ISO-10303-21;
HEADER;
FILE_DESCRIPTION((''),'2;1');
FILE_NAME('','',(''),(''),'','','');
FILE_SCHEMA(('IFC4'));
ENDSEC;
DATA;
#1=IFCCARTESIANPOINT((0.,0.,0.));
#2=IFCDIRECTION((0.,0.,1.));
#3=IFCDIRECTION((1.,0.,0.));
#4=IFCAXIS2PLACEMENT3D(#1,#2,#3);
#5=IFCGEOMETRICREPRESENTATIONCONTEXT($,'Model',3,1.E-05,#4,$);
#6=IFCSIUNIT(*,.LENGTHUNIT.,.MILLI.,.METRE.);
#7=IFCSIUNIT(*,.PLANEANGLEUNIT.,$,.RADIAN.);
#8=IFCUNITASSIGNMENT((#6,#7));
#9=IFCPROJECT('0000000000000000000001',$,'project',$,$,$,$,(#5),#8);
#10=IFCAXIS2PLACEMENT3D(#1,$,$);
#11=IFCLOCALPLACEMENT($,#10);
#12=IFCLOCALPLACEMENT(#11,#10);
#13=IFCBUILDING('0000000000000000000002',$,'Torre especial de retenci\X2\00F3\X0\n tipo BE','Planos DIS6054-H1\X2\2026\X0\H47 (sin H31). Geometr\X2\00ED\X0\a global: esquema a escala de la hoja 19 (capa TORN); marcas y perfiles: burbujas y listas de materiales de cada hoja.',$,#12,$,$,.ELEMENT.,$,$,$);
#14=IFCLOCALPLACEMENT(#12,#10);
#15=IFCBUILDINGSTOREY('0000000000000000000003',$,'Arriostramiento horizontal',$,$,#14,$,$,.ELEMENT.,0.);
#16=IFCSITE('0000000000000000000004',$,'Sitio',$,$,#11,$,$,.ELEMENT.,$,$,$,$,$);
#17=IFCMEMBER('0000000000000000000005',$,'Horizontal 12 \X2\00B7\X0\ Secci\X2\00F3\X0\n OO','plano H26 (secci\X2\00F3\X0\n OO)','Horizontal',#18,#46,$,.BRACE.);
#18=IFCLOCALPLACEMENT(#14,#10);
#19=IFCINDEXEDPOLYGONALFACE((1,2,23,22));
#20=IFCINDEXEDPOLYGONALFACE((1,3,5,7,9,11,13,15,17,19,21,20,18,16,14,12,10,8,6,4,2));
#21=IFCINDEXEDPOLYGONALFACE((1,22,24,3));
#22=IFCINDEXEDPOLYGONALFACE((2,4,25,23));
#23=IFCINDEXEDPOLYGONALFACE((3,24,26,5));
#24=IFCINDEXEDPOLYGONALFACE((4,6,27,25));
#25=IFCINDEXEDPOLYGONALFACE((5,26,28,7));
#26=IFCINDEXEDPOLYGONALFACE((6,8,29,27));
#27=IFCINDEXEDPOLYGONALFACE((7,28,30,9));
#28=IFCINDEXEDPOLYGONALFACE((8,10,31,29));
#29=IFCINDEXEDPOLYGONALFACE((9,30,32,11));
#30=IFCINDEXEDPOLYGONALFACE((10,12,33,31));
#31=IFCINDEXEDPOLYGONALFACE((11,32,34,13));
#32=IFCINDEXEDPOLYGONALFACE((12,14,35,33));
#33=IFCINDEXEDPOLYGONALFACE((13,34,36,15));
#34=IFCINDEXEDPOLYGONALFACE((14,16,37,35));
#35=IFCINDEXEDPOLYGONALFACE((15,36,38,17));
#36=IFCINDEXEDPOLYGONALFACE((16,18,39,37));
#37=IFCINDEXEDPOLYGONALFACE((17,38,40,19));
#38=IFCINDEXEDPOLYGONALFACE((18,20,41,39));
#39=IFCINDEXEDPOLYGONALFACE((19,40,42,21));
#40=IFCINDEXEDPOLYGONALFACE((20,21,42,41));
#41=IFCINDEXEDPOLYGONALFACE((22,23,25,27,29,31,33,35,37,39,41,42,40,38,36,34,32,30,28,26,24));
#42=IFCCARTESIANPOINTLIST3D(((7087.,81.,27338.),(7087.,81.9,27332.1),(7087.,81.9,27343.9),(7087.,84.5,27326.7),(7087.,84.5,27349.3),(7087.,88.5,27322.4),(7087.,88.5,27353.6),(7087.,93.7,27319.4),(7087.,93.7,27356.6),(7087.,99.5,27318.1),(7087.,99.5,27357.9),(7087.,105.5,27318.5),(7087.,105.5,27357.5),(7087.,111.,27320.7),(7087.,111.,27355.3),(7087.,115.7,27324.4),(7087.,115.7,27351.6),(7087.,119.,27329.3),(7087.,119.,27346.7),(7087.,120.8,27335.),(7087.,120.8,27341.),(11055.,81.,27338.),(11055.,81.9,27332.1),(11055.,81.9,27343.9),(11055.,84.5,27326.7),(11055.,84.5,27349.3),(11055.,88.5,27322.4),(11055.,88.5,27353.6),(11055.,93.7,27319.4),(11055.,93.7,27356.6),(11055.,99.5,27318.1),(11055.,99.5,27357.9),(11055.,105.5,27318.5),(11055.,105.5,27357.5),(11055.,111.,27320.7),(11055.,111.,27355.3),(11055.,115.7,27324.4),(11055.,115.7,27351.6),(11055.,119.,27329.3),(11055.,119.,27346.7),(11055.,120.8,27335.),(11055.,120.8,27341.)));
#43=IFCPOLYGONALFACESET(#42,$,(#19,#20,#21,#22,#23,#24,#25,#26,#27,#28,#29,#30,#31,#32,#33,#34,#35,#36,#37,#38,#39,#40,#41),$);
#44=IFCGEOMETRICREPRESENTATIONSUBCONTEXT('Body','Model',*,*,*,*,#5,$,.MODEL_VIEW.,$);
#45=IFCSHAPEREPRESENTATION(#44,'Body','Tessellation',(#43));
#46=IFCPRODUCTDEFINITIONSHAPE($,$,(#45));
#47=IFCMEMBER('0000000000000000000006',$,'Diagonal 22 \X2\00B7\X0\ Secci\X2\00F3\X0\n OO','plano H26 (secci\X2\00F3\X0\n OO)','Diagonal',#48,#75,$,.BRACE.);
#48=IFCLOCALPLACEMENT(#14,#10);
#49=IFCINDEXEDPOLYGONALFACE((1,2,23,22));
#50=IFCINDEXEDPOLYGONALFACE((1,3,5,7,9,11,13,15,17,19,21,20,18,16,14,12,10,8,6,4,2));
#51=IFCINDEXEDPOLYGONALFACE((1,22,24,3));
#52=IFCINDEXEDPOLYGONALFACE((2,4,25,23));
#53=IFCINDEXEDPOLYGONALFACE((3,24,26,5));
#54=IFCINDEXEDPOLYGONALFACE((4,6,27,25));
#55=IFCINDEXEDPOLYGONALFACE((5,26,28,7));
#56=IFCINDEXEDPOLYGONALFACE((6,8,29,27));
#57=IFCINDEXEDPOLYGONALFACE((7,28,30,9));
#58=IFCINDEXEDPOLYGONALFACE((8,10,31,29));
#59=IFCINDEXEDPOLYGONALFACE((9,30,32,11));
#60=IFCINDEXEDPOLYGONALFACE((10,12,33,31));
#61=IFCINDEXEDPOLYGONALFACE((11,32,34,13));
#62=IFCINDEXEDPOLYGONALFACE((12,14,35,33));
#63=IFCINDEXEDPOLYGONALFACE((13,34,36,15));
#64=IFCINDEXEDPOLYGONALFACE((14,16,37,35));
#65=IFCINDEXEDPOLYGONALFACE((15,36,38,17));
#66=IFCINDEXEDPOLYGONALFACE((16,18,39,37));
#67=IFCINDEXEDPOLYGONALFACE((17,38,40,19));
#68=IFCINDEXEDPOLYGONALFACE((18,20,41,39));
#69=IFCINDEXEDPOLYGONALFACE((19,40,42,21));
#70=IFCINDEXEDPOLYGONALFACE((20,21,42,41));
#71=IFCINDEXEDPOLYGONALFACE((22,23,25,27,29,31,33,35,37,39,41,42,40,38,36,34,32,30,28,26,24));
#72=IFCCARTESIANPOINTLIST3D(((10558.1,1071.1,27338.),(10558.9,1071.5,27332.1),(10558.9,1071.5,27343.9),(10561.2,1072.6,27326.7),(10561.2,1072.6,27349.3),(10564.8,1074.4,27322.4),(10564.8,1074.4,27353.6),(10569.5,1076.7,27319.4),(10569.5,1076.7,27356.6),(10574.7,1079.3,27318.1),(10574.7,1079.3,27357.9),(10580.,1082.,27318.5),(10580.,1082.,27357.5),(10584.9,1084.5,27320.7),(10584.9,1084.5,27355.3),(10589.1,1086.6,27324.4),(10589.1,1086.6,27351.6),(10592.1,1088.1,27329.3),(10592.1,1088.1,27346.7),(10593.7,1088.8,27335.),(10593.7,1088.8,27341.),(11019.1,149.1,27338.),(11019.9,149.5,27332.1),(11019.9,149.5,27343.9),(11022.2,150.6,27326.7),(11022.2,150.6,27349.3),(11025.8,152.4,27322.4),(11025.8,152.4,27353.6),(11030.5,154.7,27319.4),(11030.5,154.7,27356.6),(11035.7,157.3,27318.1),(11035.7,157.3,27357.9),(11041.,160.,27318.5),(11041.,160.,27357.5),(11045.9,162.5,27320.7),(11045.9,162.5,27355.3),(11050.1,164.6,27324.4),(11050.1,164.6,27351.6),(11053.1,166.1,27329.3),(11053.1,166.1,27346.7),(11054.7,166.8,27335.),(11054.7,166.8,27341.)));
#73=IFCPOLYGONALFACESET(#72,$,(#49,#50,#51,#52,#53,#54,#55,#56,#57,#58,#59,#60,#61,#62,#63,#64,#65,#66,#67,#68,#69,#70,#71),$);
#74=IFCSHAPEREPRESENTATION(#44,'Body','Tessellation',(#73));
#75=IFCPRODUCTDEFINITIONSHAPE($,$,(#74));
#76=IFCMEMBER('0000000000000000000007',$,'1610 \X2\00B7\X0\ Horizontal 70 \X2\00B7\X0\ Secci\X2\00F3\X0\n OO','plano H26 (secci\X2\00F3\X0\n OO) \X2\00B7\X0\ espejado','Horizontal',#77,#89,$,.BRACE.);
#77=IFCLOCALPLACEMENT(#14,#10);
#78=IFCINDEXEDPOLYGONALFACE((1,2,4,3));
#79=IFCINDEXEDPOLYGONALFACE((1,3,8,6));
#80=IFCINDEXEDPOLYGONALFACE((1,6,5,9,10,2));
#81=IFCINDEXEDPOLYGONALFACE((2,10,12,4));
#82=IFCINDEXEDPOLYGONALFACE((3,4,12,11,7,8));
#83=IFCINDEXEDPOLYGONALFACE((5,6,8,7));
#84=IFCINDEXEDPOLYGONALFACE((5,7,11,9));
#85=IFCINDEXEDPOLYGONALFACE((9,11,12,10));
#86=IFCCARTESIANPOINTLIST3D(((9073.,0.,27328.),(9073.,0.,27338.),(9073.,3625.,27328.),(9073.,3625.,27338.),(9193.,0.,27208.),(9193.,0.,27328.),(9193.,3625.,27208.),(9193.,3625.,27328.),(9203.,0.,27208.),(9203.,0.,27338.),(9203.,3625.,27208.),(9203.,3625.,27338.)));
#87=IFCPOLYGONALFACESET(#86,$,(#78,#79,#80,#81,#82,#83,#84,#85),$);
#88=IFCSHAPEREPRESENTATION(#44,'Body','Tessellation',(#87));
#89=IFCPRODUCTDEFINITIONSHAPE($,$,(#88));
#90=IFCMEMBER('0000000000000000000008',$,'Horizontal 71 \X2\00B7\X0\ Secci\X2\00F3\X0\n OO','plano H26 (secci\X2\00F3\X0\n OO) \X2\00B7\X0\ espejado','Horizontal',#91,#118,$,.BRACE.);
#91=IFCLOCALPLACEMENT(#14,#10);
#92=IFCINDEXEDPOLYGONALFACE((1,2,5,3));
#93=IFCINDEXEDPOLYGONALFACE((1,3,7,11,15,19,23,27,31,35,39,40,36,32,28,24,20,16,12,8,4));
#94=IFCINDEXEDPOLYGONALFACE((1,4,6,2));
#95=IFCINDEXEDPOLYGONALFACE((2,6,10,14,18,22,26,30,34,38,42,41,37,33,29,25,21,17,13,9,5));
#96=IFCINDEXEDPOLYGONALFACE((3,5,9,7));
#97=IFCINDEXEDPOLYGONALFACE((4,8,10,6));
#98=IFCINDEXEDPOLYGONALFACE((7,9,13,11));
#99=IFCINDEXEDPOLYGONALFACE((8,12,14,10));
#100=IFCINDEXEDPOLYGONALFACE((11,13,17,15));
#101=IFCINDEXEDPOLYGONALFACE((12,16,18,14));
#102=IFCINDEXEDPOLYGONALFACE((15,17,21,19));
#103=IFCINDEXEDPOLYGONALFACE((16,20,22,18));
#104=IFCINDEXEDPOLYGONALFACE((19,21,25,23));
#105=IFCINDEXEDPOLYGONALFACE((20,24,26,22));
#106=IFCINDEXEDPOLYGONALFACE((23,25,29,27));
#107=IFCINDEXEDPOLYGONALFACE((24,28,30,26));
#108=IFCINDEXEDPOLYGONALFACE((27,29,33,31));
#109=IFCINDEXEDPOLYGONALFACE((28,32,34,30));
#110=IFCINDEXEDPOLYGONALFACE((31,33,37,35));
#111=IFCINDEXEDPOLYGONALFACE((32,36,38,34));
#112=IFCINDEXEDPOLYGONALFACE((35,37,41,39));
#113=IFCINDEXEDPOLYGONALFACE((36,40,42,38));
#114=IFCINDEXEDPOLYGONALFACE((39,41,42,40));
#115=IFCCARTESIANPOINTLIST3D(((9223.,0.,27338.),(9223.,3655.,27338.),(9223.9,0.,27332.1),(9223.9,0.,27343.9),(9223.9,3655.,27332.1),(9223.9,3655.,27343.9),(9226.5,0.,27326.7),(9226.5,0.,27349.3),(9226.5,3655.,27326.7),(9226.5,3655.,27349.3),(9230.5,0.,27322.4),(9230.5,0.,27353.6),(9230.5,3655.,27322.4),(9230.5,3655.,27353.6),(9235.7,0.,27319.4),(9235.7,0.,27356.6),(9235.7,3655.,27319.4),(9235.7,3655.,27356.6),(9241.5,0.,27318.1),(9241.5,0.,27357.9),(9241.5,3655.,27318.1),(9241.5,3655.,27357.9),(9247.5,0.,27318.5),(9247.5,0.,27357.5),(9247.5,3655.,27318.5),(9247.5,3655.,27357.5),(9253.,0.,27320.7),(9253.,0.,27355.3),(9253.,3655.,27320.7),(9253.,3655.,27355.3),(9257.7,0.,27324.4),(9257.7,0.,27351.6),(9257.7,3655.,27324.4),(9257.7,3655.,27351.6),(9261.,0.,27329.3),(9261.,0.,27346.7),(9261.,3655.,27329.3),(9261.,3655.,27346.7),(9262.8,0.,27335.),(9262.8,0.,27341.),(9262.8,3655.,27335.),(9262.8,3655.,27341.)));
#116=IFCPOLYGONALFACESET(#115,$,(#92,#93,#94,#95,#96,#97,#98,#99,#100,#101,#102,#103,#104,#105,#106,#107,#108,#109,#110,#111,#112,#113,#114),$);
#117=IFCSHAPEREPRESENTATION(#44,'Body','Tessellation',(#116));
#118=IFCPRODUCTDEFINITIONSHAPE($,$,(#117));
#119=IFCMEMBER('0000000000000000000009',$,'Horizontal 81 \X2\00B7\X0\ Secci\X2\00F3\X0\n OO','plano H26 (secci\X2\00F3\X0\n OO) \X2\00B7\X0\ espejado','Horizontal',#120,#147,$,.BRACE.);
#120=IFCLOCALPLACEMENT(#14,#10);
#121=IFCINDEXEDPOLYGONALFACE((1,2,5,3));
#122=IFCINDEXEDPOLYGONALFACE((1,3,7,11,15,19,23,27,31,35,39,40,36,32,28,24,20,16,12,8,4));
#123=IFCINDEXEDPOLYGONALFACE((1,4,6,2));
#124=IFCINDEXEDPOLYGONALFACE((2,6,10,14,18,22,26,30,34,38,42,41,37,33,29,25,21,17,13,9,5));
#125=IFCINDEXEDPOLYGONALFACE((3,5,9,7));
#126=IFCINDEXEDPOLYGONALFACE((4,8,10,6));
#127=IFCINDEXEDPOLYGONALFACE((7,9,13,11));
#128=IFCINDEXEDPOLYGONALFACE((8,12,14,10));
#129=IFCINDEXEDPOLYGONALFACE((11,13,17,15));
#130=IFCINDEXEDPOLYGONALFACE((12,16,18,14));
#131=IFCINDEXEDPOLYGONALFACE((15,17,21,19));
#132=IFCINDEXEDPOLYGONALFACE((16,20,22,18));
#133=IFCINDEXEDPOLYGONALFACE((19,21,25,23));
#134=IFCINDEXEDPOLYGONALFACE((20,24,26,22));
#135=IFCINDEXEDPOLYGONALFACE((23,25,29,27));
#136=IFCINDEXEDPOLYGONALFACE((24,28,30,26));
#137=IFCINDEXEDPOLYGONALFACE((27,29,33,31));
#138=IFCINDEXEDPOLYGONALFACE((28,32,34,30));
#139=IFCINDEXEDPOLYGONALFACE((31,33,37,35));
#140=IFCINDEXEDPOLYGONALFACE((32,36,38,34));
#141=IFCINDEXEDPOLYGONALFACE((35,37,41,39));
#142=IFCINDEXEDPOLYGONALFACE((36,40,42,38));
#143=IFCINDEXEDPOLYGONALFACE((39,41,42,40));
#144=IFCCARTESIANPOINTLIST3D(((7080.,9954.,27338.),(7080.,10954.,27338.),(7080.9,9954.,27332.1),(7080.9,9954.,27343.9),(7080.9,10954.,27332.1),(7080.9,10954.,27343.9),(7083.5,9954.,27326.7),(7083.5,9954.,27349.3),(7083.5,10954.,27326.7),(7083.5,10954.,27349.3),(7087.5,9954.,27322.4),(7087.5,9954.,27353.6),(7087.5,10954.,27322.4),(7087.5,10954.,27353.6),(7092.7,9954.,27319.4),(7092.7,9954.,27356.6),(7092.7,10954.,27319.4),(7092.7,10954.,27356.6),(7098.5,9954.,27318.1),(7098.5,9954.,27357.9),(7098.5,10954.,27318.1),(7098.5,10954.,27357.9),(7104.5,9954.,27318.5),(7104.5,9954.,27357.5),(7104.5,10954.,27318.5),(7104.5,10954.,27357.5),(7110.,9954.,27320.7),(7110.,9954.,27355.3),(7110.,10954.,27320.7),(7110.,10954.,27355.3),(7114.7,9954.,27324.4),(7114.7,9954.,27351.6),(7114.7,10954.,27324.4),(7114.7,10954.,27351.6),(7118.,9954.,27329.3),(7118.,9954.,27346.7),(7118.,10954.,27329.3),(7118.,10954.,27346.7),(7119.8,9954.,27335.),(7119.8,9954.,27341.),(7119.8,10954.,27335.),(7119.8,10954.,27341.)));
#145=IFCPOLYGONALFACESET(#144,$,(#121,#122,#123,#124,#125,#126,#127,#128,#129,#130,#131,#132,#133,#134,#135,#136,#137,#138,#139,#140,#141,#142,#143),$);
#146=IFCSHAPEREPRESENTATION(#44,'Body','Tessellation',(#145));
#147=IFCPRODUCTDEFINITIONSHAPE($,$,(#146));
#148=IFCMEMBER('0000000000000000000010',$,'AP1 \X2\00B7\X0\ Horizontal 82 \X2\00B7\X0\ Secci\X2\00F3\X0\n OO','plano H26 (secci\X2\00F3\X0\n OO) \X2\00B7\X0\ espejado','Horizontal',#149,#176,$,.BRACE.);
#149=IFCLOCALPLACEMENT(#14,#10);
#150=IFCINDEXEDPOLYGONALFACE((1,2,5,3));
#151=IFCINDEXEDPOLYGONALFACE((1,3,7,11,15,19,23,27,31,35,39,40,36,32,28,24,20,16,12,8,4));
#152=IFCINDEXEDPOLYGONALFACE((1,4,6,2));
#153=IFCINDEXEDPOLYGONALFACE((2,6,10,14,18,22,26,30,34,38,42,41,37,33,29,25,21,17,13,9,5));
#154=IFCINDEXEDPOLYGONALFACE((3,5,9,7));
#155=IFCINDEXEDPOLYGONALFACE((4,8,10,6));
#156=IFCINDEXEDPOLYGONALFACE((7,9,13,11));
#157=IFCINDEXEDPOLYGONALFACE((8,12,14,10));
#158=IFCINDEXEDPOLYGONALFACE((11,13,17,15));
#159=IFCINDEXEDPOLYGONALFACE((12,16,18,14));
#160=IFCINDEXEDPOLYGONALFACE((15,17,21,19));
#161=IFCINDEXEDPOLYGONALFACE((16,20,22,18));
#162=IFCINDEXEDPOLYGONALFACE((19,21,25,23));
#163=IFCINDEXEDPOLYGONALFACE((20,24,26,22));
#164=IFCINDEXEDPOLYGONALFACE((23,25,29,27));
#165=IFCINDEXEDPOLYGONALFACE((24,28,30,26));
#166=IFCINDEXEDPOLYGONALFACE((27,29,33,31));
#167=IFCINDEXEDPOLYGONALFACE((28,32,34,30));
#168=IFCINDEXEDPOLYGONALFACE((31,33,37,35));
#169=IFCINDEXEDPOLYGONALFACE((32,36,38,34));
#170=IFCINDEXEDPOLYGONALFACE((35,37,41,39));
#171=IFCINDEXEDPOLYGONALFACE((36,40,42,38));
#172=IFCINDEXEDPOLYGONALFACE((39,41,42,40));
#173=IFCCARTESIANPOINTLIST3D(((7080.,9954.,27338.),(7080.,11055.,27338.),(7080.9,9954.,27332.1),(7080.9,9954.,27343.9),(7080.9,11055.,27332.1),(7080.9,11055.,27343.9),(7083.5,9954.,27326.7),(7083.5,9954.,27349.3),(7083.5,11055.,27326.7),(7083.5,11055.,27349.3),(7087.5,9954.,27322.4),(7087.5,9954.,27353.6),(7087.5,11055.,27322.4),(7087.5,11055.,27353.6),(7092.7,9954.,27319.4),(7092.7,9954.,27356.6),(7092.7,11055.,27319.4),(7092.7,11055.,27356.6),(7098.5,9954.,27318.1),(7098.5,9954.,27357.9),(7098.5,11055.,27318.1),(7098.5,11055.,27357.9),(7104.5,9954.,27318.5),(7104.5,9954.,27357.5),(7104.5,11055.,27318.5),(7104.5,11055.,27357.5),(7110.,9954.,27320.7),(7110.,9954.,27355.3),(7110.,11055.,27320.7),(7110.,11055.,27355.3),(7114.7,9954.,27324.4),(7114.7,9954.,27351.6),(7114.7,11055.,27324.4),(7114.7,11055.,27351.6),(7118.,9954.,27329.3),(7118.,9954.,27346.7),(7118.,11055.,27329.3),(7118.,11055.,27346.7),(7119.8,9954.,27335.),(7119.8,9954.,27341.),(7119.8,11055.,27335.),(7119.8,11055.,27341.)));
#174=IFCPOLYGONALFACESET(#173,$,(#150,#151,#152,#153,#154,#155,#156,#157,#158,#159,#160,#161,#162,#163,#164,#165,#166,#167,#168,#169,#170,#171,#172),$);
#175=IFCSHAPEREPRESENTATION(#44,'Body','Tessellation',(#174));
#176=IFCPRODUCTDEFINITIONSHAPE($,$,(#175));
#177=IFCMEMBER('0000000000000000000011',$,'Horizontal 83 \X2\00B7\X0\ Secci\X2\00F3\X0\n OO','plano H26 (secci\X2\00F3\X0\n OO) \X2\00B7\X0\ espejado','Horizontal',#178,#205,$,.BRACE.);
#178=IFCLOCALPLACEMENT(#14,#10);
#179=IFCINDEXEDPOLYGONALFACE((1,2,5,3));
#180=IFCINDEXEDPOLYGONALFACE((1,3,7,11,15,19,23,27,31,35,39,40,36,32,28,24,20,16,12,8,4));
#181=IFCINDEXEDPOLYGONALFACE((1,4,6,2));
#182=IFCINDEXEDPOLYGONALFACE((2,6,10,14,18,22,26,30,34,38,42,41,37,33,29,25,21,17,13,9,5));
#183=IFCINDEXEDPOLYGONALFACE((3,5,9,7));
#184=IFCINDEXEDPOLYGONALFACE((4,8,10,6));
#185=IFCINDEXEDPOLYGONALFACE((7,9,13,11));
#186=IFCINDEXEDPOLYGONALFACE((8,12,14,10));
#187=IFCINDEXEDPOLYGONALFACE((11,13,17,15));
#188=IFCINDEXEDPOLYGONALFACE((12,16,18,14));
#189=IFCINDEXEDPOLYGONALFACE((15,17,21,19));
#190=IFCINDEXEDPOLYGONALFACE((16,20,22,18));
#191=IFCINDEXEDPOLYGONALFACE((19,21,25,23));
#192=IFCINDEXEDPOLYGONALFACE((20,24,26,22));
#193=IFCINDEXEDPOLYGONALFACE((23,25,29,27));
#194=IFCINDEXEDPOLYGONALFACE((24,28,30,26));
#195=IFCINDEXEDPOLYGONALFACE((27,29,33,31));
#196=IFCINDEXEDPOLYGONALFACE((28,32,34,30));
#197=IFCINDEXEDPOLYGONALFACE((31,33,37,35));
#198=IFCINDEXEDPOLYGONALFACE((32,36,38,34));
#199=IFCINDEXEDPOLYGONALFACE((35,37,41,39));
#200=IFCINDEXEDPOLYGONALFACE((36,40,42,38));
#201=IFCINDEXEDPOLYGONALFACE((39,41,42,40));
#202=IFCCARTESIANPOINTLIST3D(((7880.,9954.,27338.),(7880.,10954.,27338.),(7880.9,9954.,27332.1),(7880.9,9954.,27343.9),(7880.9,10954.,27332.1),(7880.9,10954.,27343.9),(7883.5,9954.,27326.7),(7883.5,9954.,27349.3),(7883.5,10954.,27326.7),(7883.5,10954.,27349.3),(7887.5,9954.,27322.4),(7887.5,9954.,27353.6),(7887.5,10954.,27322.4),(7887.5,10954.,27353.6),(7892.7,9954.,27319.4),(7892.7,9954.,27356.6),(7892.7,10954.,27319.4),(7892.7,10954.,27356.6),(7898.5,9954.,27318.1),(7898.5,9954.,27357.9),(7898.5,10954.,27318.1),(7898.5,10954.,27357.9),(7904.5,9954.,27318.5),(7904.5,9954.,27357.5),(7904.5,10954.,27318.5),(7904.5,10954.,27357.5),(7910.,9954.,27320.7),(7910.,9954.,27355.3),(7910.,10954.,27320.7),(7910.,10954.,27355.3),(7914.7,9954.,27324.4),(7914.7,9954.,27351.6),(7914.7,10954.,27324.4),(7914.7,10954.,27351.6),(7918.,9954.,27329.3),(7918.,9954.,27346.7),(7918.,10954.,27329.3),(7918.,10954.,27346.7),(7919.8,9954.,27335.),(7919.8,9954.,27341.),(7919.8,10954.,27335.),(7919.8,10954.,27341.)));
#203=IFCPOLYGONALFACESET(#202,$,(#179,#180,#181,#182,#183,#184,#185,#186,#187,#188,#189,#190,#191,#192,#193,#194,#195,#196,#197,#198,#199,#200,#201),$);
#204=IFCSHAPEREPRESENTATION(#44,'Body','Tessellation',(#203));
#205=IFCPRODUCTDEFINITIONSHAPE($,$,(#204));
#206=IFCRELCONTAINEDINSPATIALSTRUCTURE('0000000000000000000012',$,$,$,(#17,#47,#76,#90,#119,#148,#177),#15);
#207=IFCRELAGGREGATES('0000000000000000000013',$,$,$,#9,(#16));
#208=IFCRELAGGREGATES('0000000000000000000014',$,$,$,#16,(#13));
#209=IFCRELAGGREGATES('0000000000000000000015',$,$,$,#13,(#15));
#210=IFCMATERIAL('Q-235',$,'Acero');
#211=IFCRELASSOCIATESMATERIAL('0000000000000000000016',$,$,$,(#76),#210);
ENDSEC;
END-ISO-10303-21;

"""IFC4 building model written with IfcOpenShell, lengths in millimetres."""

from ifc_helpers import new_model, si_unit, frame, frame_2d, origin, origin_with_axes, place, context, subcontext, project, spatial, circle, l_section, extrude, material, element, save


model = new_model("IFC4")

# Units and contexts
model_context = context("Model", 3, precision=1e-05, world=origin_with_axes())
body_context = subcontext(model_context, "Body", "Model", "MODEL_VIEW")
ifc_project = project(units=[si_unit("LENGTHUNIT", "METRE", prefix="MILLI"), si_unit("PLANEANGLEUNIT", "RADIAN")], contexts=[model_context])

# Site, building, storey
site_placement = place(None, origin())
site = spatial("IfcSite", under=ifc_project, at=site_placement, Name="Sitio", CompositionType="ELEMENT")
building_placement = place(site_placement, origin())
building = spatial("IfcBuilding", under=site, at=building_placement, Name="Torre especial de retención tipo BE", Description="Planos DIS6054-H1…H47 (sin H31). Geometría global: esquema a escala de la hoja 19 (capa TORN); marcas y perfiles: burbujas y listas de materiales de cada hoja.", CompositionType="ELEMENT")
storey_placement = place(building_placement, origin())
storey = spatial("IfcBuildingStorey", under=building, at=storey_placement, Name="Arriostramiento horizontal", CompositionType="ELEMENT", Elevation=0.0)

# Members
member_1_placement = place(storey_placement, frame((7087.0, 101.0, 27338.0), z_axis=(1.0, 0.0, 0.0), x_axis=(0.0, -1.0, 0.0)))
element("IfcMember", 1, at=member_1_placement, inside=storey, Name="Horizontal 12 · Sección OO", Description="plano H26 (sección OO)", ObjectType="Horizontal", PredefinedType="BRACE", context=body_context, shape_type="SweptSolid", body=[
    extrude(circle(Radius=20.0), None, (0.0, 0.0, 1.0), 3968.0),
])
member_2_placement = place(storey_placement, frame((10576.0, 1080.0, 27338.0), z_axis=(0.447214, -0.894427, 0.0), x_axis=(-0.894427, -0.447214, 0.0)))
element("IfcMember", 2, at=member_2_placement, inside=storey, Name="Diagonal 22 · Sección OO", Description="plano H26 (sección OO)", ObjectType="Diagonal", PredefinedType="BRACE", context=body_context, shape_type="SweptSolid", body=[
    extrude(circle(Radius=20.0), None, (0.0, 0.0, 1.0), 1030.8),
])
ifc_material = material(Name="Q-235", Category="Acero")
member_3_placement = place(storey_placement, frame((9203.0, 3625.0, 27338.0), z_axis=(0.0, -1.0, 0.0), x_axis=(-1.0, 0.0, 0.0)))
element("IfcMember", 3, at=member_3_placement, inside=storey, material=ifc_material, Name="1610 · Horizontal 70 · Sección OO", Description="plano H26 (sección OO) · espejado", ObjectType="Horizontal", PredefinedType="BRACE", context=body_context, shape_type="SweptSolid", body=[
    extrude(l_section(Depth=130.0, Width=130.0, Thickness=10.0, at=frame_2d((65.0, 65.0))), None, (0.0, 0.0, 1.0), 3625.0),
])
member_4_placement = place(storey_placement, frame((9243.0, 3655.0, 27338.0), z_axis=(0.0, -1.0, 0.0), x_axis=(-1.0, 0.0, 0.0)))
element("IfcMember", 4, at=member_4_placement, inside=storey, Name="Horizontal 71 · Sección OO", Description="plano H26 (sección OO) · espejado", ObjectType="Horizontal", PredefinedType="BRACE", context=body_context, shape_type="SweptSolid", body=[
    extrude(circle(Radius=20.0), None, (0.0, 0.0, 1.0), 3655.0),
])
member_5_placement = place(storey_placement, frame((7100.0, 9954.0, 27338.0), z_axis=(0.0, 1.0, 0.0), x_axis=(-1.0, 0.0, 0.0)))
element("IfcMember", 5, at=member_5_placement, inside=storey, Name="Horizontal 81 · Sección OO", Description="plano H26 (sección OO) · espejado", ObjectType="Horizontal", PredefinedType="BRACE", context=body_context, shape_type="SweptSolid", body=[
    extrude(circle(Radius=20.0), None, (0.0, 0.0, 1.0), 1000.0),
])
member_6_placement = place(storey_placement, frame((7100.0, 9954.0, 27338.0), z_axis=(0.0, 1.0, 0.0), x_axis=(-1.0, 0.0, 0.0)))
element("IfcMember", 6, at=member_6_placement, inside=storey, Name="AP1 · Horizontal 82 · Sección OO", Description="plano H26 (sección OO) · espejado", ObjectType="Horizontal", PredefinedType="BRACE", context=body_context, shape_type="SweptSolid", body=[
    extrude(circle(Radius=20.0), None, (0.0, 0.0, 1.0), 1101.0),
])
for number, where, z_axis, x_axis, name in (
    (7, (7900.0, 9954.0, 27338.0), (0.0, 1.0, 0.0), (-1.0, 0.0, 0.0), "Horizontal 83 · Sección OO"),
):
    element("IfcMember", number, at=place(storey_placement, frame(where, z_axis=z_axis, x_axis=x_axis)), inside=storey, Name=name, Description="plano H26 (sección OO) · espejado", ObjectType="Horizontal", PredefinedType="BRACE", context=body_context, shape_type="SweptSolid", body=[
        extrude(circle(Radius=20.0), None, (0.0, 0.0, 1.0), 1000.0),
    ])

save(model, "model.ifc")
